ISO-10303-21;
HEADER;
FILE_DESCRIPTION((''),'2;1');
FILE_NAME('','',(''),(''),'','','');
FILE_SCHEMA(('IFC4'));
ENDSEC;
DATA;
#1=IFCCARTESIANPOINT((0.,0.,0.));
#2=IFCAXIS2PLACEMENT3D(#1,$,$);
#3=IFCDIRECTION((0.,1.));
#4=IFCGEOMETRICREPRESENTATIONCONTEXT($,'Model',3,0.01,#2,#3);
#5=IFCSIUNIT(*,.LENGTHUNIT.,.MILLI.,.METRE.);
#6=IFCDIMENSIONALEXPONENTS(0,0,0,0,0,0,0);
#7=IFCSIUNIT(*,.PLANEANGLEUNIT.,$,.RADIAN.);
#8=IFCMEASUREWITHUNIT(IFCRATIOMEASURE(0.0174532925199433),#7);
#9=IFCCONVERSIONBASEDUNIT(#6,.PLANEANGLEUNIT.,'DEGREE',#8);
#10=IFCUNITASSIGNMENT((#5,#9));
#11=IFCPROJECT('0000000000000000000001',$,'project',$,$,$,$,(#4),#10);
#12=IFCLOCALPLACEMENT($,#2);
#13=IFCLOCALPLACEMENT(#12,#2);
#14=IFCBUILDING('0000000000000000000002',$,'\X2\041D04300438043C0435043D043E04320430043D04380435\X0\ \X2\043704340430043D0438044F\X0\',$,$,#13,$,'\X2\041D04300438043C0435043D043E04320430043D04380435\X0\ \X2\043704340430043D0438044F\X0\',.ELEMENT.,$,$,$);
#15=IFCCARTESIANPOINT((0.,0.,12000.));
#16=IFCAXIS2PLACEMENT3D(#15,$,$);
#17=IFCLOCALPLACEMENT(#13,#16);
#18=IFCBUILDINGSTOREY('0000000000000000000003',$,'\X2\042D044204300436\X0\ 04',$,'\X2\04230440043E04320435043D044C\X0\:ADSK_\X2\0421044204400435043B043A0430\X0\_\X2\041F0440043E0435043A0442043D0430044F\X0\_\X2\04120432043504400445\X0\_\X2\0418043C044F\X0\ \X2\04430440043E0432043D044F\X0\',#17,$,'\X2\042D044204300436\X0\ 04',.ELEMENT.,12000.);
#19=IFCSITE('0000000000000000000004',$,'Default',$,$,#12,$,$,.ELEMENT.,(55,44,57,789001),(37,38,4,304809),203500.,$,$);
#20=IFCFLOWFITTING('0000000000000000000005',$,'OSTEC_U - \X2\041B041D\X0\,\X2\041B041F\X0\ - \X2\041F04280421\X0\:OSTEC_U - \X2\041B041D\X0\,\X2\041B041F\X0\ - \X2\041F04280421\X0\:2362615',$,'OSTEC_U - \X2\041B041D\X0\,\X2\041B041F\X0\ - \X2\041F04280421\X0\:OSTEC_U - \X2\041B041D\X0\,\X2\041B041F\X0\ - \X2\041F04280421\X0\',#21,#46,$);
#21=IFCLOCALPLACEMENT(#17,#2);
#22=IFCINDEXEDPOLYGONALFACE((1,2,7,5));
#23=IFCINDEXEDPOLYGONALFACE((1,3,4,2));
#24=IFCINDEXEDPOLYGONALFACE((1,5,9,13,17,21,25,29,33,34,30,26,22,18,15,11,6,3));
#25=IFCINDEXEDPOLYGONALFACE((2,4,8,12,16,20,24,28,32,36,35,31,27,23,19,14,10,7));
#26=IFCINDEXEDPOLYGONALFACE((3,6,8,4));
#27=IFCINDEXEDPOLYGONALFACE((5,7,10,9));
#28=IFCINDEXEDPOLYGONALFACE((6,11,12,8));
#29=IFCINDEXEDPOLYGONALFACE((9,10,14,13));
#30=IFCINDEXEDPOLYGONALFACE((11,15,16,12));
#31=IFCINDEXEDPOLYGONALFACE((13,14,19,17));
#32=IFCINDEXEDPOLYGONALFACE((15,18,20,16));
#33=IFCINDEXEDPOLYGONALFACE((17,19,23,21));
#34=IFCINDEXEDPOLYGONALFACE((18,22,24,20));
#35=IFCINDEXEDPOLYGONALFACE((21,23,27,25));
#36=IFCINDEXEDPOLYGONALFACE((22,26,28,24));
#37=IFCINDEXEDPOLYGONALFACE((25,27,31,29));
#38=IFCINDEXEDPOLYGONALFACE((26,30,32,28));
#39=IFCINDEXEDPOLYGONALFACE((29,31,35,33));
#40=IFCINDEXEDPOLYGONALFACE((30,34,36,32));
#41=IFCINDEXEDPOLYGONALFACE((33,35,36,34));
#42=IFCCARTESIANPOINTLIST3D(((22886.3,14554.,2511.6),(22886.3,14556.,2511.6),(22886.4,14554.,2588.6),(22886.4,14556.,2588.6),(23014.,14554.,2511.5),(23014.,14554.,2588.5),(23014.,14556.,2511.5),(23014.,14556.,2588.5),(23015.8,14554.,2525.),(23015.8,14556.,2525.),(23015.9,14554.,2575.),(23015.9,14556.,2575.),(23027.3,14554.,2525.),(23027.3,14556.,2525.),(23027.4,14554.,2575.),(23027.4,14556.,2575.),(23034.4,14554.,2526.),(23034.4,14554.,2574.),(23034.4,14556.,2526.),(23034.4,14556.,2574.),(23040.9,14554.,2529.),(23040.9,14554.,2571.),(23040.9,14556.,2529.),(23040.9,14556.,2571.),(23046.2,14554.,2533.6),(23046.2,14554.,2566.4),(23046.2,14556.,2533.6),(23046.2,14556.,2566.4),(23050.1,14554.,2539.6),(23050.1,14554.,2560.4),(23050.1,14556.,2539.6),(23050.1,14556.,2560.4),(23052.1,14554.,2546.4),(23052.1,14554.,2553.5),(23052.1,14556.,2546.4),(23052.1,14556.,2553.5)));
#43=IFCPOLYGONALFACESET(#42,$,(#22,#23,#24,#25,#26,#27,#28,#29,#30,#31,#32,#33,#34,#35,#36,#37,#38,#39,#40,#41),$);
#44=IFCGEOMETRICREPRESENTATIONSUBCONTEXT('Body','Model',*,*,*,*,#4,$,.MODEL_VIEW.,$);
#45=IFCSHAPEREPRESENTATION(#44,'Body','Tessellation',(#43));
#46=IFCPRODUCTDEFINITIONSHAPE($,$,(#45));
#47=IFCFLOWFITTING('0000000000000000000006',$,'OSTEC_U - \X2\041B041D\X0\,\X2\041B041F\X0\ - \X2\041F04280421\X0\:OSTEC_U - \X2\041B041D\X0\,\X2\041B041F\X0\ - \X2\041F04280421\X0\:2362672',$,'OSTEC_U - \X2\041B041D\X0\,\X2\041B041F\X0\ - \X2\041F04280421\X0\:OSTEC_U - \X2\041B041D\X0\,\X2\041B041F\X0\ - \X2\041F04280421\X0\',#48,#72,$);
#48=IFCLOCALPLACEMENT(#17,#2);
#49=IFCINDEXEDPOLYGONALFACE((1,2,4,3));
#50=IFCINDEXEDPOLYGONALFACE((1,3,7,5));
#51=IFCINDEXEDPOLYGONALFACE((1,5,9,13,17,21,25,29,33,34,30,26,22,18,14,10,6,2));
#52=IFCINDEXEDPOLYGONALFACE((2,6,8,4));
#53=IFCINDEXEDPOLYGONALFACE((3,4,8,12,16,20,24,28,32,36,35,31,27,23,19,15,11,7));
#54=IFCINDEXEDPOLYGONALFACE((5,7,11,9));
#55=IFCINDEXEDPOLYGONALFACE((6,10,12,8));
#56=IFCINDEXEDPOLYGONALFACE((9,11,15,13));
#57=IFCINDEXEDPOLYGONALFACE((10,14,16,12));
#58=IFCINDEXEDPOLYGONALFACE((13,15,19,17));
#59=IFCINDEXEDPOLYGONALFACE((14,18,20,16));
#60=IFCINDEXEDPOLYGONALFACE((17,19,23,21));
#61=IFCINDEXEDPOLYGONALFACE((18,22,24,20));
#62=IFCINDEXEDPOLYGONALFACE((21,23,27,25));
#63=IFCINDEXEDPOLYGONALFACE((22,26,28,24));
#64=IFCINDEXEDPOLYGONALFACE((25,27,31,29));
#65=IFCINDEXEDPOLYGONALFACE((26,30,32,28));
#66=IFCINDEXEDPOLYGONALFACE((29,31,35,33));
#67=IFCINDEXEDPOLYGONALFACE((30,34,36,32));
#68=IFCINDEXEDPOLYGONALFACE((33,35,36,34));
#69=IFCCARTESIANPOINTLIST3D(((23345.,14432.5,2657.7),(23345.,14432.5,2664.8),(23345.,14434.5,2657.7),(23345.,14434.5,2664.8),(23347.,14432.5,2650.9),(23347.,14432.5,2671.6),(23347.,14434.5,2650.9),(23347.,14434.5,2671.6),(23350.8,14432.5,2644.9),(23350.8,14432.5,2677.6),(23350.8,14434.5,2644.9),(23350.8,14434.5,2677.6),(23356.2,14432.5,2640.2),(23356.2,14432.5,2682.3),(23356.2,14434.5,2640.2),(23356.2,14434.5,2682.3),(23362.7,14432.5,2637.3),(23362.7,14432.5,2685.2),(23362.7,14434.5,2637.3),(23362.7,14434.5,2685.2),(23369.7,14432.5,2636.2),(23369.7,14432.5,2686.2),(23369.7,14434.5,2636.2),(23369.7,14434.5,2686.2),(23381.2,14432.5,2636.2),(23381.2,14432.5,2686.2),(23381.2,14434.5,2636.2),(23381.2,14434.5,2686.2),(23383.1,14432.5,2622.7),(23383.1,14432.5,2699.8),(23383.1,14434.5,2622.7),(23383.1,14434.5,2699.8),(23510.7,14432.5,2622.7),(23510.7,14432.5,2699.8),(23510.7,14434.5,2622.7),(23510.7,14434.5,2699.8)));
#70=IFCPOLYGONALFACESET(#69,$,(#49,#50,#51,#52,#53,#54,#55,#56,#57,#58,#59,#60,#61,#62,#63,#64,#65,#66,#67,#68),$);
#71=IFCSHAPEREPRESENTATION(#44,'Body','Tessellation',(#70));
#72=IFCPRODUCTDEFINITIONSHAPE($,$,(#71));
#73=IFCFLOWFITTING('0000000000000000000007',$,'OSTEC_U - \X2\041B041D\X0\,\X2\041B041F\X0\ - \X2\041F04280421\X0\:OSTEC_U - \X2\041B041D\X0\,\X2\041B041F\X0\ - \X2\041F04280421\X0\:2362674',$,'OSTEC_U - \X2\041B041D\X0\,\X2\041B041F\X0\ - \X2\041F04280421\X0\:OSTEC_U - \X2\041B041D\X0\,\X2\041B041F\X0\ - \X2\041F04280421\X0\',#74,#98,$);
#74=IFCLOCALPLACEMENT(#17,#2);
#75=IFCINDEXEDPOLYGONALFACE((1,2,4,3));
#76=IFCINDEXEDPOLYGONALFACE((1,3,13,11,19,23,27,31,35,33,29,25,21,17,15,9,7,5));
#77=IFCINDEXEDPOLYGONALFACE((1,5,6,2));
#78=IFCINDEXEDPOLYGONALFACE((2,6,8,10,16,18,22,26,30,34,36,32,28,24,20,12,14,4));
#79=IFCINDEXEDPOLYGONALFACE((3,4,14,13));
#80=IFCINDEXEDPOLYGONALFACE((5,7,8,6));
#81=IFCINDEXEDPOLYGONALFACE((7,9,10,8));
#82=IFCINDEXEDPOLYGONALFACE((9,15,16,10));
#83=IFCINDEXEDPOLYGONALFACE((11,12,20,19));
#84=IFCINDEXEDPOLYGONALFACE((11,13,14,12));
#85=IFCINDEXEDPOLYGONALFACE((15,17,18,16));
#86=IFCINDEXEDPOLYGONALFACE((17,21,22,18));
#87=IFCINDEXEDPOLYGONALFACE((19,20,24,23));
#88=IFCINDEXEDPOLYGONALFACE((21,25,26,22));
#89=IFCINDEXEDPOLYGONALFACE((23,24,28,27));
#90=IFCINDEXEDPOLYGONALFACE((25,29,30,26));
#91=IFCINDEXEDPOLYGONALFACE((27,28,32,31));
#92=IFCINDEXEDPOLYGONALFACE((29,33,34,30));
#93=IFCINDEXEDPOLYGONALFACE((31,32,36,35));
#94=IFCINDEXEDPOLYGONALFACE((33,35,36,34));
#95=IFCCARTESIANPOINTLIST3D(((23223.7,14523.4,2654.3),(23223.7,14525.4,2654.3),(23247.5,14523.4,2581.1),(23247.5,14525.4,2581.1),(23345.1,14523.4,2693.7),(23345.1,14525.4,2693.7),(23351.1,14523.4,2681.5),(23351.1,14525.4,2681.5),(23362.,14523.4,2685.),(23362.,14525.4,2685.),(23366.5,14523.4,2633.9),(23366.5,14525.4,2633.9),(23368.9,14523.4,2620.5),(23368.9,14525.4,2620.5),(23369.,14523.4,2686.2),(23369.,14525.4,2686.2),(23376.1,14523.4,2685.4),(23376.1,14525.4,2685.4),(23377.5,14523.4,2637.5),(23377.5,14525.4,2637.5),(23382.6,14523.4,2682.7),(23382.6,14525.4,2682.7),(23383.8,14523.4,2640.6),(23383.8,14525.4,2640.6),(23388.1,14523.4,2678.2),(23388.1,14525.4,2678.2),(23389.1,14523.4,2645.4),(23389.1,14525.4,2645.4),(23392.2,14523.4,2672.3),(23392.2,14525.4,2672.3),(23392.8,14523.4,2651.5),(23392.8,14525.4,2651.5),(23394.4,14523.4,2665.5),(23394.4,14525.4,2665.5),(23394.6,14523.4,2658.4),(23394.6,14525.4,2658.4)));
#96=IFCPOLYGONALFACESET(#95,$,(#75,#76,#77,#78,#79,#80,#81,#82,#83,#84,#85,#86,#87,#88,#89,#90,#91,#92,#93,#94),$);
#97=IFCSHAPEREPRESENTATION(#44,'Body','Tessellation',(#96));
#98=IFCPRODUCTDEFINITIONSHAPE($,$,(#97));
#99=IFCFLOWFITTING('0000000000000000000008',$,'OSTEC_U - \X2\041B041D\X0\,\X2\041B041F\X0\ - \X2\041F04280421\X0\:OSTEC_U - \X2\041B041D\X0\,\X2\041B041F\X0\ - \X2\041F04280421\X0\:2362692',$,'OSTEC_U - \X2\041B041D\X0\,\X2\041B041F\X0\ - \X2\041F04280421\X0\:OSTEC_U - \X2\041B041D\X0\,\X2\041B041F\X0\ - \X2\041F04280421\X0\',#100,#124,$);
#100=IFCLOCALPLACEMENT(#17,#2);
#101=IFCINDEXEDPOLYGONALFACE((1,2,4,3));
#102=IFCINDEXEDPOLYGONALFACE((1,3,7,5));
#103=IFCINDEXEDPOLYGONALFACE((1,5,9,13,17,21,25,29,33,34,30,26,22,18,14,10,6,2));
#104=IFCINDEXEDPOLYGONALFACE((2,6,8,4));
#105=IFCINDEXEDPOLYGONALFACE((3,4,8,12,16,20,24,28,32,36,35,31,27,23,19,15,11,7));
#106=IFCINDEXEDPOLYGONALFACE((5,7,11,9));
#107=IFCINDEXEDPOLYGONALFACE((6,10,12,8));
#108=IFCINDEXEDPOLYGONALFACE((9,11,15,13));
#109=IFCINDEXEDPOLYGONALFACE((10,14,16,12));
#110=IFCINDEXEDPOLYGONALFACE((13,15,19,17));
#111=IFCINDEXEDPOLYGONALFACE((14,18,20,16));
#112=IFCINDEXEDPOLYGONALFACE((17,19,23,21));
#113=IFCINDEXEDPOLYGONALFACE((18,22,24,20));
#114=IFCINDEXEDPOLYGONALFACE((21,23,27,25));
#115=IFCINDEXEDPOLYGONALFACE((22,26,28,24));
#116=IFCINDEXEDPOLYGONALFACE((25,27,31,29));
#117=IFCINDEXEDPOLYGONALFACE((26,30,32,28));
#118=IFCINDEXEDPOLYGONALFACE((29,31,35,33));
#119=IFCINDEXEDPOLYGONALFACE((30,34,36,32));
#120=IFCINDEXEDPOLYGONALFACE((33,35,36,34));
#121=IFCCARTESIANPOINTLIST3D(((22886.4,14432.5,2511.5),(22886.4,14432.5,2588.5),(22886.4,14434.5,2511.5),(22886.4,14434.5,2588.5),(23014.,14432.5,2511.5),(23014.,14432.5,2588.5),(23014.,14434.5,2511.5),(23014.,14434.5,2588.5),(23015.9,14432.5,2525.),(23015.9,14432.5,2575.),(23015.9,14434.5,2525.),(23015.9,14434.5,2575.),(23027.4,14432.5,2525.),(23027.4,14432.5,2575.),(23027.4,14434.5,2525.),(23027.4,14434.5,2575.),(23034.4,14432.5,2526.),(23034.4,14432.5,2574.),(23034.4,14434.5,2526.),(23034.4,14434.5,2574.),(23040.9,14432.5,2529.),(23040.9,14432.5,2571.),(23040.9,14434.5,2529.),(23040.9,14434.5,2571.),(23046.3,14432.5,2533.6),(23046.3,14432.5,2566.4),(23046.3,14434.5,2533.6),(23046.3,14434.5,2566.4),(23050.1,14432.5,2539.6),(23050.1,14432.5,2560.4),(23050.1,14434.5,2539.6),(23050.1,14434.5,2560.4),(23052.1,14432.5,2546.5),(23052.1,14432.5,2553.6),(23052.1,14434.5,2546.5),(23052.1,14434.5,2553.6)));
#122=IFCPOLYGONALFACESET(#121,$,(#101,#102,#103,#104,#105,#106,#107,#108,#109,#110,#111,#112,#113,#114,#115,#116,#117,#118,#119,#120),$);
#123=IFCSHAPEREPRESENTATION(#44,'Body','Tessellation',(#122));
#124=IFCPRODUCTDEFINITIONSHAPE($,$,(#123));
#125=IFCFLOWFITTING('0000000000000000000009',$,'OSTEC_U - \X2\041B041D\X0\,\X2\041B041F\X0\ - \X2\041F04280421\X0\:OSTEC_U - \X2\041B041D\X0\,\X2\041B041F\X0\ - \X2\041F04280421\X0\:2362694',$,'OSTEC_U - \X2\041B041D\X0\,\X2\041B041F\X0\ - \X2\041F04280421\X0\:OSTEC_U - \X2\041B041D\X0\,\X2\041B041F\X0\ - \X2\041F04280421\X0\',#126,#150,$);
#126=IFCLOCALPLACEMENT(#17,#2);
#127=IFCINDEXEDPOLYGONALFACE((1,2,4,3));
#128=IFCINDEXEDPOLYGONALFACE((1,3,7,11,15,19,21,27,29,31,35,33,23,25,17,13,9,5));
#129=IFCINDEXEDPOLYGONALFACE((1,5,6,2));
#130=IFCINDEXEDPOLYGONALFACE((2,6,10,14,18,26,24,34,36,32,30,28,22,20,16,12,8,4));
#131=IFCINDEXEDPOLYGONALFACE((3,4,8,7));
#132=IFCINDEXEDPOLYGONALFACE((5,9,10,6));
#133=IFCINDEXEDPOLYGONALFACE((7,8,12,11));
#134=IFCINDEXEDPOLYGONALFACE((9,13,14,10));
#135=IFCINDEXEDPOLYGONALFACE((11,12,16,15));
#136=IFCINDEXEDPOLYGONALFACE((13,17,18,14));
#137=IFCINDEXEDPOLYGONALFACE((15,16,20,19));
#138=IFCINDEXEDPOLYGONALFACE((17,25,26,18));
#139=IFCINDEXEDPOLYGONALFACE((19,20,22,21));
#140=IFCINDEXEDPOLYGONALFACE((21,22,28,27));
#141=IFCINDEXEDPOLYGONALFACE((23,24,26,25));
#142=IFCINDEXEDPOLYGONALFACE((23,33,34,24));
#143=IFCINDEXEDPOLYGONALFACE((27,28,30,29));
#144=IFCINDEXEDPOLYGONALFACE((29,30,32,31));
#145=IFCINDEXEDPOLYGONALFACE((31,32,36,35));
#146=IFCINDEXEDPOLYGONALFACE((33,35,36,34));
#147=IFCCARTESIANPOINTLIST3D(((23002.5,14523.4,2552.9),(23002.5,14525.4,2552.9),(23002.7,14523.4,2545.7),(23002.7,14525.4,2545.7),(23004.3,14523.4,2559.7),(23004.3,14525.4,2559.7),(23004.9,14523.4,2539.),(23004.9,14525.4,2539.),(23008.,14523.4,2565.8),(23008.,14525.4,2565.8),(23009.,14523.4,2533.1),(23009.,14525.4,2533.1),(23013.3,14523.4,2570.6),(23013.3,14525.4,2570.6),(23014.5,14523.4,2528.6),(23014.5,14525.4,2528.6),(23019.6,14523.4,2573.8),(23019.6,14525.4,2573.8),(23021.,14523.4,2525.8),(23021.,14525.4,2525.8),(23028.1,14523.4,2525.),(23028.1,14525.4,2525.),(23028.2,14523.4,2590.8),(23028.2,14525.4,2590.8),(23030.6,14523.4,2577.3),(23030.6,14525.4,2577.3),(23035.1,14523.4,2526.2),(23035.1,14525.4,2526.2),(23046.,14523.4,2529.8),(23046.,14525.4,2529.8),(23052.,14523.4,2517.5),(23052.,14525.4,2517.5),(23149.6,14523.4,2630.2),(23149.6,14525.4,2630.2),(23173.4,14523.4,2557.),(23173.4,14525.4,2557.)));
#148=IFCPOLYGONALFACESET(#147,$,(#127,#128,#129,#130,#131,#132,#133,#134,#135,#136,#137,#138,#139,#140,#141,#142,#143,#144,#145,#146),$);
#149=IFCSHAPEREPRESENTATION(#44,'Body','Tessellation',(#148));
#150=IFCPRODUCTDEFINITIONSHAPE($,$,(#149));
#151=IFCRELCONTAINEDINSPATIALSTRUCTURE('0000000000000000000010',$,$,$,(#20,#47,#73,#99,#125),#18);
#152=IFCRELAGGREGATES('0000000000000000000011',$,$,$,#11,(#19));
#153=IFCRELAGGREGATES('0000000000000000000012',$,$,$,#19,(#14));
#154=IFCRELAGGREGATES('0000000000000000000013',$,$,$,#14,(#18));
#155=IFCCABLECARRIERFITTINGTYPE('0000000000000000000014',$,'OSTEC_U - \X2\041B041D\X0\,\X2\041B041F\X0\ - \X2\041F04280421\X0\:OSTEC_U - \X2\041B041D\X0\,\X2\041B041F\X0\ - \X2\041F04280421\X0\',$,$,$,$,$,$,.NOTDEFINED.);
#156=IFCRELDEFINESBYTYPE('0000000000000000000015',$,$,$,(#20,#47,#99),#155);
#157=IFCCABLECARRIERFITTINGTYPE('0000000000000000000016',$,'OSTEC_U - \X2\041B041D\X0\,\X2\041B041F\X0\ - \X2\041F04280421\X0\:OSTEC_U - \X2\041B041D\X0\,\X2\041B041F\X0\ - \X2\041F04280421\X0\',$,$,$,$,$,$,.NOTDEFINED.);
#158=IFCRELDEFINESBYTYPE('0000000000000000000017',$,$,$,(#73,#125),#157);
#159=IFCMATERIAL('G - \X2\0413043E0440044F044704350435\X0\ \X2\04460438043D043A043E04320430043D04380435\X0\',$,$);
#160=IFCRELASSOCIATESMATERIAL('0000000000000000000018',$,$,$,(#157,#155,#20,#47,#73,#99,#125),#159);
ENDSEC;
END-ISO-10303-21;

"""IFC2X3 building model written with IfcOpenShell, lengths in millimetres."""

from ifc_helpers import new_model, entity, si_unit, converted_unit, direction, frame, frame_2d, origin, place, context, subcontext, project, spatial, polyline, circle_curve, parameter, trimmed, segment, composite_curve, outline, extrude, source, transform, mapped, material, type_object, type_shapes, element, save


model = new_model("IFC2X3")

# Units and contexts
model_context = context("Model", 3, precision=0.01, world=origin(), true_north=direction((0.0, 1.0)))
body_context = subcontext(model_context, "Body", "Model", "MODEL_VIEW")
ifc_project = project(units=[si_unit("LENGTHUNIT", "METRE", prefix="MILLI"), converted_unit("PLANEANGLEUNIT", "DEGREE", entity("IfcRatioMeasure", 0.0174532925199433), si_unit("PLANEANGLEUNIT", "RADIAN"), dimensions=[0, 0, 0, 0, 0, 0, 0])], contexts=[model_context])

# Site, building, storey
site_placement = place(None, origin())
site = spatial("IfcSite", under=ifc_project, at=site_placement, Name="Default", CompositionType="ELEMENT", RefLatitude=(55, 44, 57, 789001), RefLongitude=(37, 38, 4, 304809), RefElevation=203500.0)
building_placement = place(site_placement, origin())
building = spatial("IfcBuilding", under=site, at=building_placement, Name="Наименование здания", LongName="Наименование здания", CompositionType="ELEMENT")
storey_placement = place(building_placement, frame((0.0, 0.0, 12000.0)))
storey = spatial("IfcBuildingStorey", under=building, at=storey_placement, Name="Этаж 04", ObjectType="Уровень:ADSK_Стрелка_Проектная_Вверх_Имя уровня", LongName="Этаж 04", CompositionType="ELEMENT", Elevation=12000.0)

# Flow fittings
ifc_material = material(Name="G - Горячее цинкование")
cable_carrier_fitting_type_1 = type_object("IfcCableCarrierFittingType", Name="OSTEC_U - ЛН,ЛП - ПШС:OSTEC_U - ЛН,ЛП - ПШС", PredefinedType="NOTDEFINED", material=ifc_material)
shared_shape_1 = source(origin(), body_context, "Body", "SweptSolid", [
    extrude(outline(composite_curve([segment(trimmed(circle_curve(frame_2d((-41.5, 0.0), x_axis=(1.0, 0.0)), 25.0), [parameter(90.0)], [parameter(270.0)], True, "PARAMETER"), True, "CONTINUOUS"), segment(polyline([(-41.5, -25.0), (-30.0, -25.0)]), True, "CONTINUOUS"), segment(polyline([(-30.0, -25.0), (-28.1, -38.5)]), True, "CONTINUOUS"), segment(polyline([(-28.1, -38.5), (99.5, -38.5)]), True, "CONTINUOUS"), segment(polyline([(99.5, -38.5), (99.5, 38.5)]), True, "CONTINUOUS"), segment(polyline([(99.5, 38.5), (-28.1, 38.5)]), True, "CONTINUOUS"), segment(polyline([(-28.1, 38.5), (-30.0, 25.0)]), True, "CONTINUOUS"), segment(polyline([(-30.0, 25.0), (-41.5, 25.0)]), True, "CONTINUOUS")], self_intersect=False)), frame((41.5, 0.0, 0.0)), (0.0, 0.0, 1.0), 2.0),
])
type_shapes(cable_carrier_fitting_type_1, [shared_shape_1])
cable_carrier_fitting_type_2 = type_object("IfcCableCarrierFittingType", Name="OSTEC_U - ЛН,ЛП - ПШС:OSTEC_U - ЛН,ЛП - ПШС", PredefinedType="NOTDEFINED", material=ifc_material)
type_shapes(cable_carrier_fitting_type_2, [shared_shape_1])
for number, where, z_axis, x_axis, name in (
    (1, (23027.3, 14556.0, 2550.0), (0.0, -1.0, 0.0), (-1.0, 0.0, 0.000378), "OSTEC_U - ЛН,ЛП - ПШС:OSTEC_U - ЛН,ЛП - ПШС:2362615"),
    (2, (23369.7, 14434.5, 2661.2), (0.0, -1.0, 0.0), (1.0, 0.0, 0.0), "OSTEC_U - ЛН,ЛП - ПШС:OSTEC_U - ЛН,ЛП - ПШС:2362672"),
):
    element("IfcFlowFitting", number, at=place(storey_placement, frame(where, z_axis=z_axis, x_axis=x_axis)), inside=storey, type_object=cable_carrier_fitting_type_2, material=ifc_material, Name=name, ObjectType="OSTEC_U - ЛН,ЛП - ПШС:OSTEC_U - ЛН,ЛП - ПШС", context=body_context, shape_type="MappedRepresentation", body=[
        mapped(shared_shape_1, transform((0.0, 0.0, 0.0), scale=1.0)),
    ])
flow_fitting_1_placement = place(storey_placement, frame((23369.7, 14523.5, 2661.2), z_axis=(0.0, 1.0, 0.0), x_axis=(-0.951057, 0.0, -0.309017)))
element("IfcFlowFitting", 3, at=flow_fitting_1_placement, inside=storey, type_object=cable_carrier_fitting_type_1, material=ifc_material, Name="OSTEC_U - ЛН,ЛП - ПШС:OSTEC_U - ЛН,ЛП - ПШС:2362674", ObjectType="OSTEC_U - ЛН,ЛП - ПШС:OSTEC_U - ЛН,ЛП - ПШС", context=body_context, shape_type="MappedRepresentation", body=[
    mapped(shared_shape_1, transform((0.0, 0.0, 0.0), scale=1.0)),
])
flow_fitting_2_placement = place(storey_placement, frame((23027.4, 14434.5, 2550.0), z_axis=(0.0, -1.0, 0.0), x_axis=(-1.0, 0.0, -0.000002)))
element("IfcFlowFitting", 4, at=flow_fitting_2_placement, inside=storey, type_object=cable_carrier_fitting_type_2, material=ifc_material, Name="OSTEC_U - ЛН,ЛП - ПШС:OSTEC_U - ЛН,ЛП - ПШС:2362692", ObjectType="OSTEC_U - ЛН,ЛП - ПШС:OSTEC_U - ЛН,ЛП - ПШС", context=body_context, shape_type="MappedRepresentation", body=[
    mapped(shared_shape_1, transform((0.0, 0.0, 0.0), scale=1.0)),
])
flow_fitting_3_placement = place(storey_placement, frame((23027.4, 14523.5, 2550.0), z_axis=(0.0, 1.0, 0.0), x_axis=(0.951057, 0.0, 0.309017)))
element("IfcFlowFitting", 5, at=flow_fitting_3_placement, inside=storey, type_object=cable_carrier_fitting_type_1, material=ifc_material, Name="OSTEC_U - ЛН,ЛП - ПШС:OSTEC_U - ЛН,ЛП - ПШС:2362694", ObjectType="OSTEC_U - ЛН,ЛП - ПШС:OSTEC_U - ЛН,ЛП - ПШС", context=body_context, shape_type="MappedRepresentation", body=[
    mapped(shared_shape_1, transform((0.0, 0.0, 0.0), scale=1.0)),
])

save(model, "model.ifc")
